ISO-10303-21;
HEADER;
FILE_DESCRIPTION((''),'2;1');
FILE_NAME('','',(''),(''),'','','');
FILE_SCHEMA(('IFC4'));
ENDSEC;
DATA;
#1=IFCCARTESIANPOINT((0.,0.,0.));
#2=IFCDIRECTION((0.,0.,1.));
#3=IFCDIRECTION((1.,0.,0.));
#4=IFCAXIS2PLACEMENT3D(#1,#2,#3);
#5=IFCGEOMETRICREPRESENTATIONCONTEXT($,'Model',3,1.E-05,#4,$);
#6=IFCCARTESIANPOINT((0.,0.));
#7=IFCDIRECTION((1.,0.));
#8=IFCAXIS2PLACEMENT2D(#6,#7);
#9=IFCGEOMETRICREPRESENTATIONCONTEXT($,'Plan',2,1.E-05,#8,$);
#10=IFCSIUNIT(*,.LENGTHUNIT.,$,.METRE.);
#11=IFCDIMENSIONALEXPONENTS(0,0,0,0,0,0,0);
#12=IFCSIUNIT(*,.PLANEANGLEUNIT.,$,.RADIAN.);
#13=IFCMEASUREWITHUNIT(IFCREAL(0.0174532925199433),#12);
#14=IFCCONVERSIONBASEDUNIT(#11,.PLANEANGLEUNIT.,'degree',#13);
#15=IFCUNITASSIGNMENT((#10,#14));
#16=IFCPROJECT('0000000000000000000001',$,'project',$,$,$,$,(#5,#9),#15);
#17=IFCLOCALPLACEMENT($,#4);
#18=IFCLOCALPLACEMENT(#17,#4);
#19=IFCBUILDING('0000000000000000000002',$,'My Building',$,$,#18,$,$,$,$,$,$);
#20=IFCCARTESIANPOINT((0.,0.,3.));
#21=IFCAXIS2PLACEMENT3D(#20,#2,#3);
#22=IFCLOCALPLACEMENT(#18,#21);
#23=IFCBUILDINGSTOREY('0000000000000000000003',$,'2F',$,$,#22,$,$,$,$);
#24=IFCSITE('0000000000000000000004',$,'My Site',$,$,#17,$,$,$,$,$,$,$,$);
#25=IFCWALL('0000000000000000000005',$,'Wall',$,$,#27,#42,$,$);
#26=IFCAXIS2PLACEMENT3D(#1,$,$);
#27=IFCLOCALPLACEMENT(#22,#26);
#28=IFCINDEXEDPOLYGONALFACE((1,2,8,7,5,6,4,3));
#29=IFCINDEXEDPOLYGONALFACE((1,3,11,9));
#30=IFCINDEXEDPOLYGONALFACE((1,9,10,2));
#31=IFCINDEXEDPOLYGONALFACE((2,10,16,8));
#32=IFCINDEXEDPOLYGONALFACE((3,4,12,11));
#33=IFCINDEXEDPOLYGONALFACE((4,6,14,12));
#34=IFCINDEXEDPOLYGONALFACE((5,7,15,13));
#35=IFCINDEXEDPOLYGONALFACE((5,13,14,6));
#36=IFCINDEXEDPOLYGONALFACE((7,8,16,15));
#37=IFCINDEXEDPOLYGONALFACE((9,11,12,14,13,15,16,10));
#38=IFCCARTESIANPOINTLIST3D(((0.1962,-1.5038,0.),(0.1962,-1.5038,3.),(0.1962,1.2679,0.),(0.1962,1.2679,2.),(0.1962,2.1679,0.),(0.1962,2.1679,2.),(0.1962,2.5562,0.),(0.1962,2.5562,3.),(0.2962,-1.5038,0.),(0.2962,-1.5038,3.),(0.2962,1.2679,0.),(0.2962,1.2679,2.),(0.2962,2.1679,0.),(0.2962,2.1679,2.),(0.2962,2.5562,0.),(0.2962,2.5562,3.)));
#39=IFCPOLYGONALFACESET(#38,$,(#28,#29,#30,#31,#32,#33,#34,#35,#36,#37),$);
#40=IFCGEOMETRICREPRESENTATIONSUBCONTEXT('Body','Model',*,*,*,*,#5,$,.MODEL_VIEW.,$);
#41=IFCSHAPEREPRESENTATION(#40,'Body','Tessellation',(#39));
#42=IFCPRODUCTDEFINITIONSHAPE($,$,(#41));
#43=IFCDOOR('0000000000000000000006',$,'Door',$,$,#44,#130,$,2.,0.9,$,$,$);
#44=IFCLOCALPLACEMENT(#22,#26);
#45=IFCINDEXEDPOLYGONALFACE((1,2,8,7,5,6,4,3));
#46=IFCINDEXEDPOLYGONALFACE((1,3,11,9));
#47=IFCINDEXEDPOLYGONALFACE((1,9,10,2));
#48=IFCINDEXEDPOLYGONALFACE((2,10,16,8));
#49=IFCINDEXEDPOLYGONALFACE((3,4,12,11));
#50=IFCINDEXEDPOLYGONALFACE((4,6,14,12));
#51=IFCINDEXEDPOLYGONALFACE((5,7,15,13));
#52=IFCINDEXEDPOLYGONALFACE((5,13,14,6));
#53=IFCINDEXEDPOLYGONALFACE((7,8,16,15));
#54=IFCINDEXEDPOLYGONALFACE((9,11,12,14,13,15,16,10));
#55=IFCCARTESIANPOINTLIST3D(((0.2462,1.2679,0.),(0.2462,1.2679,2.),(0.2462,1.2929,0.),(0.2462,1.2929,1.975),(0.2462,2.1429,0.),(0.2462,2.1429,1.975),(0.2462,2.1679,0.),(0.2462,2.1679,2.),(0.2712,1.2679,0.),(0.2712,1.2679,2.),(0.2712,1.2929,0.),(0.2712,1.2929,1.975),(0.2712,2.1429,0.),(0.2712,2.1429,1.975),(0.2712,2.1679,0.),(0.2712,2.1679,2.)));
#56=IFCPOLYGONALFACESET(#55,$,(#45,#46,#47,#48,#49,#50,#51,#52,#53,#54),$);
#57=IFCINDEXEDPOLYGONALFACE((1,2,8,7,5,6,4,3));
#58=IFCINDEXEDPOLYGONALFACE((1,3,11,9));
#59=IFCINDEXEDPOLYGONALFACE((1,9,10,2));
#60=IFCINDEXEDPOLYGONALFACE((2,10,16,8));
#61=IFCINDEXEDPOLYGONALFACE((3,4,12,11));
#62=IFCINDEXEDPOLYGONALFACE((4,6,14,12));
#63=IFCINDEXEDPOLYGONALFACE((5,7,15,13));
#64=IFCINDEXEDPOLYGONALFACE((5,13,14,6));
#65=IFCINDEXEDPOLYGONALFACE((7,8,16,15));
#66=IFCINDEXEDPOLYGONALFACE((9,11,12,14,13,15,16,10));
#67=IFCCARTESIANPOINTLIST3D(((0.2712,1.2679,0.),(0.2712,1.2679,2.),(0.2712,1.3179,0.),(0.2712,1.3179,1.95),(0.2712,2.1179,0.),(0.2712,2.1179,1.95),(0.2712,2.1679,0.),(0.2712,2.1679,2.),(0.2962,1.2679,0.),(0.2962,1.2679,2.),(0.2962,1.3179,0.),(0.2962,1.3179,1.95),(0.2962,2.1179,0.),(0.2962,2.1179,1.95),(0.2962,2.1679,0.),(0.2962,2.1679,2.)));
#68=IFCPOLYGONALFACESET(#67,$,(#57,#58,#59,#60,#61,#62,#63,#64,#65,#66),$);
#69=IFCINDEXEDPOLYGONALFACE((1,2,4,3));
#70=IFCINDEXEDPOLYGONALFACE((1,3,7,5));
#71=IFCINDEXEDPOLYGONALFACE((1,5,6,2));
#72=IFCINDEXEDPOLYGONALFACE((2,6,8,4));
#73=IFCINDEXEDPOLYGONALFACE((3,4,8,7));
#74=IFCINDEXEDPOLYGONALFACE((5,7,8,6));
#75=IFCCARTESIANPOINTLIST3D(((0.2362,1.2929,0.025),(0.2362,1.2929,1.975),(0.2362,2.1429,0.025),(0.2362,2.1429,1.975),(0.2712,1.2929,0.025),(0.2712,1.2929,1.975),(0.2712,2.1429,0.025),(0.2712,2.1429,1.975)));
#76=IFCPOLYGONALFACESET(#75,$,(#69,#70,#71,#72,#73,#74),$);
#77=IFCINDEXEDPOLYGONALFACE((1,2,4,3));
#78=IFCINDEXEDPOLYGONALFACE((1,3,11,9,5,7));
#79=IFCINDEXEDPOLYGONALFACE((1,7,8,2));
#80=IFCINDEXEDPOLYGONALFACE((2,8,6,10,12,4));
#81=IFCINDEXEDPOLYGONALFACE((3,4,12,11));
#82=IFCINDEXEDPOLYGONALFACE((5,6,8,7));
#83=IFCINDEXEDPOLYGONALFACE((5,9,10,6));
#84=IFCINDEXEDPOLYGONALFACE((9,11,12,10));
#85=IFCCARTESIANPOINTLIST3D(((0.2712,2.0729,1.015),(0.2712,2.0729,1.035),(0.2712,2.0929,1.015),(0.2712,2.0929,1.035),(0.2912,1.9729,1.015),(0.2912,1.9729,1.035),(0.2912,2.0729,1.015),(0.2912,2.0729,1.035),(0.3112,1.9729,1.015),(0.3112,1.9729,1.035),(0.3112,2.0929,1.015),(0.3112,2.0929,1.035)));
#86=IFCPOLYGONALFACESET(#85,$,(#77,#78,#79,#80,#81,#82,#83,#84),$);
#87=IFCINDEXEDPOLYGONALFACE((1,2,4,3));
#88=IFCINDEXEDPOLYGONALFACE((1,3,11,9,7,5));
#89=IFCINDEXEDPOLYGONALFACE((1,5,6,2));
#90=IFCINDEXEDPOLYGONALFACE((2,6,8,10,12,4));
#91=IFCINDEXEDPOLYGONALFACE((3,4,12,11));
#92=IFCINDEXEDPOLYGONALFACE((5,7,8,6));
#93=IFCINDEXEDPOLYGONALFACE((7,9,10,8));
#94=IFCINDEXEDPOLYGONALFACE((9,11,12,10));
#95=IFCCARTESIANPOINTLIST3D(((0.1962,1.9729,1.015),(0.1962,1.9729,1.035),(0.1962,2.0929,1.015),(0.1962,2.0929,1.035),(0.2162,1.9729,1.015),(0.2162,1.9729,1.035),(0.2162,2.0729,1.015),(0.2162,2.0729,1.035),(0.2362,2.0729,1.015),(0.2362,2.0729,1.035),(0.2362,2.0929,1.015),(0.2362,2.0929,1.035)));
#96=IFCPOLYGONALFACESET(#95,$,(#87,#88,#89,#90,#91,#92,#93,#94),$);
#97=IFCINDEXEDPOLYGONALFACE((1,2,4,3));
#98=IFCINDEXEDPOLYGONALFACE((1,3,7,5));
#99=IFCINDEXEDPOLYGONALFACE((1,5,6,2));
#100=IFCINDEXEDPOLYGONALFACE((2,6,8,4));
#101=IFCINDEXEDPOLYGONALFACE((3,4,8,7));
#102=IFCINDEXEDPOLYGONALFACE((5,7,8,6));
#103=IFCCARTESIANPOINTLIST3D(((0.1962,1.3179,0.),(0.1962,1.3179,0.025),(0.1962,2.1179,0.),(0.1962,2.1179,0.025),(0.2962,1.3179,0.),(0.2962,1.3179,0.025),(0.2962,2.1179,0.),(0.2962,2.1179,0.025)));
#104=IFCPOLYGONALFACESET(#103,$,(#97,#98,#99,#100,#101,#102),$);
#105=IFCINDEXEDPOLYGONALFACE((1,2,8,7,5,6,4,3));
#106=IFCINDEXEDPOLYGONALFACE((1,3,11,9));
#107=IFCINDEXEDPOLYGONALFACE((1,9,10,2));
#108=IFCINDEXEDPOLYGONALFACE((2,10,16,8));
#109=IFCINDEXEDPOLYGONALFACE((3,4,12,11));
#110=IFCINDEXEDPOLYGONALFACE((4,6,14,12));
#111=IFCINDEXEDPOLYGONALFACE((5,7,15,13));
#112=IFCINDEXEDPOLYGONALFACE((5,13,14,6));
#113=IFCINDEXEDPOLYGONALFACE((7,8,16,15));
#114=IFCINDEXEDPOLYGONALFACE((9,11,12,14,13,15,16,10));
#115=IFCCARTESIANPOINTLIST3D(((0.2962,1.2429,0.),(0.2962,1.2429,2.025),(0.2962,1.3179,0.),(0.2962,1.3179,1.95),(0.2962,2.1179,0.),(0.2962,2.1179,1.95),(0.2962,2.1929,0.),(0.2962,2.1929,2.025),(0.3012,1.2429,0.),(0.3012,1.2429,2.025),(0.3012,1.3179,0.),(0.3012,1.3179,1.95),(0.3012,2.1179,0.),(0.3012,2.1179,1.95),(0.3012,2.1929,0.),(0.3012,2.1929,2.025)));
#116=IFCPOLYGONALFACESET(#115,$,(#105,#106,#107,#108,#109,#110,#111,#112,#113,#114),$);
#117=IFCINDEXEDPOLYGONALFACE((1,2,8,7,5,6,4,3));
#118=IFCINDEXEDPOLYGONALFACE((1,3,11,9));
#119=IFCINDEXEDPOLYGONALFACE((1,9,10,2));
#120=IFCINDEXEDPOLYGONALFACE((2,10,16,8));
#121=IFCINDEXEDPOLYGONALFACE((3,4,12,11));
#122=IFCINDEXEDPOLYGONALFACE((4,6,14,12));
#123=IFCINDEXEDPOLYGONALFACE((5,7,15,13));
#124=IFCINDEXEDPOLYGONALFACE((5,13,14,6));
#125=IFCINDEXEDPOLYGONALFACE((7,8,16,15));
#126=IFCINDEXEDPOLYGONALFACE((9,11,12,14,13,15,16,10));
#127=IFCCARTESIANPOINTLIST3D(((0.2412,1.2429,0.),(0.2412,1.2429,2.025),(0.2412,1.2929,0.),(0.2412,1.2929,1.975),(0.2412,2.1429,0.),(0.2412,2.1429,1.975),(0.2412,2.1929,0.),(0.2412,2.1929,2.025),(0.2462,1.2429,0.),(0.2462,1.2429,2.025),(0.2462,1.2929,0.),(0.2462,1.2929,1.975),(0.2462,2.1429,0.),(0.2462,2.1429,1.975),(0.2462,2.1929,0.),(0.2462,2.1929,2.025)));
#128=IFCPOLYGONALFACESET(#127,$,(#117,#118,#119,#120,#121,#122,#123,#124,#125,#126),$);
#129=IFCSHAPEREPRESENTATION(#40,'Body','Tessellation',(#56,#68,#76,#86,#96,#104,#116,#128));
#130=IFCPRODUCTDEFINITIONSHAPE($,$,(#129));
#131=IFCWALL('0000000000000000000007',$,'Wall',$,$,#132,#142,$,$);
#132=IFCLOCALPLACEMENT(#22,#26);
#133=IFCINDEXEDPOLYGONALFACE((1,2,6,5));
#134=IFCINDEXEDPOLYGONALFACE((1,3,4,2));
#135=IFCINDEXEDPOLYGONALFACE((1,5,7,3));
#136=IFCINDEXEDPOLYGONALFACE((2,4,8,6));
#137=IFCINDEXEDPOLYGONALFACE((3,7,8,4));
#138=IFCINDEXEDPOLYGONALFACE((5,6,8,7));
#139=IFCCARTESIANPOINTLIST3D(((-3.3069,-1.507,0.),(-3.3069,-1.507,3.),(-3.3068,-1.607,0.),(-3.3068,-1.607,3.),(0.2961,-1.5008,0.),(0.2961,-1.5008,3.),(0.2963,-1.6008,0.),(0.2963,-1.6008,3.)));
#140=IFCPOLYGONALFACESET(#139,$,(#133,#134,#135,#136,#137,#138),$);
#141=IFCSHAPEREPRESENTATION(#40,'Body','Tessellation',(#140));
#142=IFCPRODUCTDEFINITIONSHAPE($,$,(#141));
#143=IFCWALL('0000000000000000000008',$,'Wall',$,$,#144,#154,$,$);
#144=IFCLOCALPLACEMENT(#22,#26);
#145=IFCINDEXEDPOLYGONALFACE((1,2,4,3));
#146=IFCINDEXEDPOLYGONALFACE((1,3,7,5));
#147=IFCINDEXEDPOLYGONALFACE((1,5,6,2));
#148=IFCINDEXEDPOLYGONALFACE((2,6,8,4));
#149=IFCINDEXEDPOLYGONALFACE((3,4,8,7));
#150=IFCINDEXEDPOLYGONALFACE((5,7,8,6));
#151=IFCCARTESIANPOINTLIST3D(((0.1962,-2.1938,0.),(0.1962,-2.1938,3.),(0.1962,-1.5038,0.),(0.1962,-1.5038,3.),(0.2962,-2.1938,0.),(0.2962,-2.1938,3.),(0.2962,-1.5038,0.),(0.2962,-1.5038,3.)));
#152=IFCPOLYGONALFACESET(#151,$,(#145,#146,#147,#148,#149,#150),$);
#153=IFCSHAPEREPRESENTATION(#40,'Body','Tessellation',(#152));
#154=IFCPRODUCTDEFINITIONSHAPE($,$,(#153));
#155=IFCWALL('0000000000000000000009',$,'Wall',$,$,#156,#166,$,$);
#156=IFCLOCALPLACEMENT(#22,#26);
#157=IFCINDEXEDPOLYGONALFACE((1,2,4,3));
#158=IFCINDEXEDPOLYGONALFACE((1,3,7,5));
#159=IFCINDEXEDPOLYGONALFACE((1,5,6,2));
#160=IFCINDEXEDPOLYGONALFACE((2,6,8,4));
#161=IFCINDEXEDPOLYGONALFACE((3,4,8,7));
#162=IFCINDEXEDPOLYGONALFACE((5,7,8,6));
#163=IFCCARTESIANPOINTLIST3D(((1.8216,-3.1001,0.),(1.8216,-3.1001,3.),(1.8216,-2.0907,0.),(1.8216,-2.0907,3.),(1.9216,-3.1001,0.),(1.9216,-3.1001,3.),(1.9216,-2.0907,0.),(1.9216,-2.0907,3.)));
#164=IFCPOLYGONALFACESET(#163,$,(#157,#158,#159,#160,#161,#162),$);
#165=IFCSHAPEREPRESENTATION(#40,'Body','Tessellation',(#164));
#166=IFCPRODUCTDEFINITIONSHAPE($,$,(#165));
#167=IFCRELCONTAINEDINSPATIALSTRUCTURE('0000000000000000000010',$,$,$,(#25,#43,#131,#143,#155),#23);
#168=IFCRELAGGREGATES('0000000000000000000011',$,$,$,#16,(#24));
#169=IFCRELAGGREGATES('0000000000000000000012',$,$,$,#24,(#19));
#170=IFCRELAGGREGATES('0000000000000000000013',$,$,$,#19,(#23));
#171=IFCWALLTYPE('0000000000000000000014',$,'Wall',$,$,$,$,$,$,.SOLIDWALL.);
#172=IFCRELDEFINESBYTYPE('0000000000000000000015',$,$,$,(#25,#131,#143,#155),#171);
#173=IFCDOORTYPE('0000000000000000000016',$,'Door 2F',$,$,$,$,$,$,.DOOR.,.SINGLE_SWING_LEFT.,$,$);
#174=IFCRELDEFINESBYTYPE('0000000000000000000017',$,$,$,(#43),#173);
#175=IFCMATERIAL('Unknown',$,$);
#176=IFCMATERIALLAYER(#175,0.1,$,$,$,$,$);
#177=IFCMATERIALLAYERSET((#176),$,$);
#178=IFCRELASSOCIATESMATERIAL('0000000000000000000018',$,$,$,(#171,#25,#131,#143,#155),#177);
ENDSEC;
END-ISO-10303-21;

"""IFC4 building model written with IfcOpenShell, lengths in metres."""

from ifc_helpers import new_model, entity, si_unit, converted_unit, frame, origin_with_axes, origin_2d_with_axis, place, context, subcontext, project, spatial, line, indexed_curve, outline, extrude, shape, source, transform, mapped, material, layer, layer_set, layer_usage, type_object, type_shapes, element, fill, save


model = new_model("IFC4")

# Units and contexts
model_context = context("Model", 3, precision=1e-05, world=origin_with_axes())
plan_context = context("Plan", 2, precision=1e-05, world=origin_2d_with_axis())
body_context_1 = subcontext(model_context, "Body", "Model", "MODEL_VIEW")
body_context_2 = subcontext(plan_context, "Body", "Plan", "PLAN_VIEW")
ifc_project = project(units=[si_unit("LENGTHUNIT", "METRE"), converted_unit("PLANEANGLEUNIT", "degree", entity("IfcReal", 0.0174532925199433), si_unit("PLANEANGLEUNIT", "RADIAN"), dimensions=[0, 0, 0, 0, 0, 0, 0])], contexts=[model_context, plan_context])

# Site, building, storey
site_placement = place(None, origin_with_axes())
site = spatial("IfcSite", under=ifc_project, at=site_placement, Name="My Site")
building_placement = place(site_placement, origin_with_axes())
building = spatial("IfcBuilding", under=site, at=building_placement, Name="My Building")
storey_placement = place(building_placement, frame((0.0, 0.0, 3.0), z_axis=(0.0, 0.0, 1.0), x_axis=(1.0, 0.0, 0.0)))
storey = spatial("IfcBuildingStorey", under=building, at=storey_placement, Name="2F")

# Shared definitions
ifc_material = material(Name="Unknown")

# Shared definitions
ifc_layer_1 = layer(ifc_material, 0.1)
ifc_layer_set_1 = layer_set([ifc_layer_1])
wall_type = type_object("IfcWallType", Name="Wall", PredefinedType="SOLIDWALL", material=ifc_layer_set_1)

# Wall, opening, door
ifc_layer_usage_1 = layer_usage(ifc_layer_set_1, "AXIS2", "POSITIVE", 0.0)
wall_1_placement = place(storey_placement, frame((0.2962, -1.5038, 0.0), z_axis=(0.0, 0.0, 1.0), x_axis=(0.0, 1.0, 0.0)))
wall_1 = element("IfcWall", 1, at=wall_1_placement, inside=storey, type_object=wall_type, material=ifc_layer_usage_1, Name="Wall", context=body_context_1, shape_type="SweptSolid", body=[
    extrude(outline(indexed_curve([(0.0, 0.0), (0.0, 0.1), (4.06, 0.1), (4.06, 0.0)], segments=[line(1, 2, 3, 4, 1)])), origin_with_axes(), (0.0, 0.0, 1.0), 3.0),
])
shared_shape_1 = source(origin_with_axes(), body_context_1, "Body", "SweptSolid", [
    extrude(outline(indexed_curve([(0.0, 0.0), (0.9, 0.0), (0.9, 2.0), (0.0, 2.0)], segments=[line(1, 2, 3, 4, 1)])), frame((0.0, -0.6, 0.0), z_axis=(0.0, -1.0, 0.0), x_axis=(1.0, 0.0, 0.0)), (0.0, 0.0, -1.0), 1.2),
])
opening_1_placement = place(wall_1_placement, frame((2.7717, 0.0, 0.0), z_axis=(0.0, 0.0, 1.0), x_axis=(1.0, 0.0, 0.0)))
opening_1 = element("IfcOpeningElement", 2, at=opening_1_placement, cuts=wall_1, PredefinedType="OPENING", context=body_context_1, shape_type="MappedRepresentation", body=[
    mapped(shared_shape_1, transform((0.0, 0.0, 0.0), x_axis=(1.0, 0.0, 0.0), y_axis=(0.0, 1.0, 0.0), z_axis=(0.0, 0.0, 1.0), scale=1.0)),
])
door_type_1 = type_object("IfcDoorType", Name="Door 2F", OperationType="SINGLE_SWING_LEFT", PredefinedType="DOOR")
shared_shape_2 = source(origin_with_axes(), body_context_1, "Body", "SweptSolid", [
    extrude(outline(indexed_curve([(0.0, 0.0), (0.0, 2.0), (0.9, 2.0), (0.9, 0.0), (0.875, 0.0), (0.875, 1.975), (0.025, 1.975), (0.025, 0.0)], segments=[line(1, 2, 3, 4, 5, 6, 7, 8, 1)])), frame((0.0, 0.025, 0.0), z_axis=(0.0, -1.0, 0.0), x_axis=(1.0, 0.0, 0.0)), (0.0, 0.0, -1.0), 0.025),
    extrude(outline(indexed_curve([(0.0, 0.0), (0.0, 2.0), (0.9, 2.0), (0.9, 0.0), (0.85, 0.0), (0.85, 1.95), (0.05, 1.95), (0.05, 0.0)], segments=[line(1, 2, 3, 4, 5, 6, 7, 8, 1)])), frame((0.0, 0.0, 0.0), z_axis=(0.0, -1.0, 0.0), x_axis=(1.0, 0.0, 0.0)), (0.0, 0.0, -1.0), 0.025),
    extrude(outline(indexed_curve([(0.0, 0.0), (0.85, 0.0), (0.85, 0.035), (0.0, 0.035)], segments=[line(1, 2, 3, 4, 1)])), frame((0.025, 0.025, 0.025), z_axis=(0.0, 0.0, 1.0), x_axis=(1.0, 0.0, 0.0)), (0.0, 0.0, 1.0), 1.95),
    extrude(outline(indexed_curve([(0.0, 0.0), (0.0, -0.04), (-0.12, -0.04), (-0.12, -0.02), (-0.02, -0.02), (-0.02, 0.0)], segments=[line(1, 2, 3, 4, 5, 6, 1)])), frame((0.825, 0.025, 1.015), z_axis=(0.0, 0.0, 1.0), x_axis=(1.0, 0.0, 0.0)), (0.0, 0.0, 1.0), 0.02),
    extrude(outline(indexed_curve([(0.0, 0.0), (0.0, 0.04), (-0.12, 0.04), (-0.12, 0.02), (-0.02, 0.02), (-0.02, 0.0)], segments=[line(1, 2, 3, 4, 5, 6, 1)])), frame((0.825, 0.06, 1.015), z_axis=(0.0, 0.0, 1.0), x_axis=(1.0, 0.0, 0.0)), (0.0, 0.0, 1.0), 0.02),
    extrude(outline(indexed_curve([(0.0, 0.0), (0.8, 0.0), (0.8, 0.1), (0.0, 0.1)], segments=[line(1, 2, 3, 4, 1)])), frame((0.05, 0.0, 0.0), z_axis=(0.0, 0.0, 1.0), x_axis=(1.0, 0.0, 0.0)), (0.0, 0.0, 1.0), 0.025),
    extrude(outline(indexed_curve([(0.0, 0.0), (0.0, 2.025), (0.95, 2.025), (0.95, 0.0), (0.875, 0.0), (0.875, 1.95), (0.075, 1.95), (0.075, 0.0)], segments=[line(1, 2, 3, 4, 5, 6, 7, 8, 1)])), frame((-0.025, -0.005, 0.0), z_axis=(0.0, -1.0, 0.0), x_axis=(1.0, 0.0, 0.0)), (0.0, 0.0, -1.0), 0.005),
    extrude(outline(indexed_curve([(0.0, 0.0), (0.0, 2.025), (0.95, 2.025), (0.95, 0.0), (0.9, 0.0), (0.9, 1.975), (0.05, 1.975), (0.05, 0.0)], segments=[line(1, 2, 3, 4, 5, 6, 7, 8, 1)])), frame((-0.025, 0.05, 0.0), z_axis=(0.0, -1.0, 0.0), x_axis=(1.0, 0.0, 0.0)), (0.0, 0.0, -1.0), 0.005),
])
shared_shape_3 = source(origin_with_axes(), body_context_2, "Body", "Curve2D", [
    entity("IfcIndexedPolyCurve", entity("IfcCartesianPointList2D", [[0.0, 0.0], [0.0, 0.05], [0.025, 0.05], [0.025, 0.025], [0.05, 0.025], [0.05, 0.0]]), [entity("IfcLineIndex", [1, 2, 3, 4, 5, 6, 1])]),
    entity("IfcIndexedPolyCurve", entity("IfcCartesianPointList2D", [[0.9, 0.0], [0.9, 0.05], [0.875, 0.05], [0.875, 0.025], [0.85, 0.025], [0.85, 0.0]]), [entity("IfcLineIndex", [1, 2, 3, 4, 5, 6, 1])]),
    entity("IfcTrimmedCurve", entity("IfcEllipse", entity("IfcAxis2Placement2D", entity("IfcCartesianPoint", [0.06, 0.05]), entity("IfcDirection", [1.0, 0.0])), 0.815, 0.85), [entity("IfcCartesianPoint", [0.875, 0.05])], [entity("IfcCartesianPoint", [0.06, 0.9])], True, "CARTESIAN"),
    entity("IfcIndexedPolyCurve", entity("IfcCartesianPointList2D", [[0.025, 0.05], [0.06, 0.05], [0.06, 0.9], [0.025, 0.9]]), [entity("IfcLineIndex", [1, 2, 3, 4, 1])]),
])
type_shapes(door_type_1, [shared_shape_2, shared_shape_3])
door_1_placement = place(opening_1_placement, frame((0.0, 0.0, 0.0), z_axis=(0.0, 0.0, 1.0), x_axis=(1.0, 0.0, 0.0)))
door_1 = element("IfcDoor", 3, at=door_1_placement, inside=storey, type_object=door_type_1, Name="Door", OverallHeight=2.0, OverallWidth=0.9, shapes=[
    shape(body_context_1, "Body", "MappedRepresentation", [mapped(shared_shape_2, transform((0.0, 0.0, 0.0), x_axis=(1.0, 0.0, 0.0), y_axis=(0.0, 1.0, 0.0), z_axis=(0.0, 0.0, 1.0), scale=1.0))]),
    shape(body_context_2, "Body", "MappedRepresentation", [mapped(shared_shape_3, transform((0.0, 0.0, 0.0), x_axis=(1.0, 0.0, 0.0), y_axis=(0.0, 1.0, 0.0), z_axis=(0.0, 0.0, 1.0), scale=1.0))]),
])
fill(opening_1, door_1)

# Walls
ifc_layer_usage_2 = layer_usage(ifc_layer_set_1, "AXIS2", "POSITIVE", 0.0)
wall_2_placement = place(storey_placement, frame((-3.3068, -1.607, 0.0), z_axis=(0.0, 0.0, 1.0), x_axis=(0.999999, 0.001712, 0.0)))
element("IfcWall", 4, at=wall_2_placement, inside=storey, type_object=wall_type, material=ifc_layer_usage_2, Name="Wall", context=body_context_1, shape_type="SweptSolid", body=[
    extrude(outline(indexed_curve([(0.0, 0.0), (0.0, 0.1), (3.6031, 0.1), (3.6031, 0.0)], segments=[line(1, 2, 3, 4, 1)])), origin_with_axes(), (0.0, 0.0, 1.0), 3.0),
])
ifc_layer_usage_3 = layer_usage(ifc_layer_set_1, "AXIS2", "POSITIVE", 0.0)
wall_3_placement = place(storey_placement, frame((0.1962, -1.5038, 0.0), z_axis=(0.0, 0.0, 1.0), x_axis=(0.0, -1.0, 0.0)))
element("IfcWall", 5, at=wall_3_placement, inside=storey, type_object=wall_type, material=ifc_layer_usage_3, Name="Wall", context=body_context_1, shape_type="SweptSolid", body=[
    extrude(outline(indexed_curve([(0.0, 0.0), (0.0, 0.1), (0.69, 0.1), (0.69, 0.0)], segments=[line(1, 2, 3, 4, 1)])), origin_with_axes(), (0.0, 0.0, 1.0), 3.0),
])
ifc_layer_usage_4 = layer_usage(ifc_layer_set_1, "AXIS2", "POSITIVE", 0.0)
wall_4_placement = place(storey_placement, frame((1.9216, -3.1001, 0.0), z_axis=(0.0, 0.0, 1.0), x_axis=(0.000002, 1.0, 0.0)))
element("IfcWall", 6, at=wall_4_placement, inside=storey, type_object=wall_type, material=ifc_layer_usage_4, Name="Wall", context=body_context_1, shape_type="SweptSolid", body=[
    extrude(outline(indexed_curve([(0.0, 0.0), (0.0, 0.1), (1.0094, 0.1), (1.0094, 0.0)], segments=[line(1, 2, 3, 4, 1)])), origin_with_axes(), (0.0, 0.0, 1.0), 3.0),
])

save(model, "model.ifc")
